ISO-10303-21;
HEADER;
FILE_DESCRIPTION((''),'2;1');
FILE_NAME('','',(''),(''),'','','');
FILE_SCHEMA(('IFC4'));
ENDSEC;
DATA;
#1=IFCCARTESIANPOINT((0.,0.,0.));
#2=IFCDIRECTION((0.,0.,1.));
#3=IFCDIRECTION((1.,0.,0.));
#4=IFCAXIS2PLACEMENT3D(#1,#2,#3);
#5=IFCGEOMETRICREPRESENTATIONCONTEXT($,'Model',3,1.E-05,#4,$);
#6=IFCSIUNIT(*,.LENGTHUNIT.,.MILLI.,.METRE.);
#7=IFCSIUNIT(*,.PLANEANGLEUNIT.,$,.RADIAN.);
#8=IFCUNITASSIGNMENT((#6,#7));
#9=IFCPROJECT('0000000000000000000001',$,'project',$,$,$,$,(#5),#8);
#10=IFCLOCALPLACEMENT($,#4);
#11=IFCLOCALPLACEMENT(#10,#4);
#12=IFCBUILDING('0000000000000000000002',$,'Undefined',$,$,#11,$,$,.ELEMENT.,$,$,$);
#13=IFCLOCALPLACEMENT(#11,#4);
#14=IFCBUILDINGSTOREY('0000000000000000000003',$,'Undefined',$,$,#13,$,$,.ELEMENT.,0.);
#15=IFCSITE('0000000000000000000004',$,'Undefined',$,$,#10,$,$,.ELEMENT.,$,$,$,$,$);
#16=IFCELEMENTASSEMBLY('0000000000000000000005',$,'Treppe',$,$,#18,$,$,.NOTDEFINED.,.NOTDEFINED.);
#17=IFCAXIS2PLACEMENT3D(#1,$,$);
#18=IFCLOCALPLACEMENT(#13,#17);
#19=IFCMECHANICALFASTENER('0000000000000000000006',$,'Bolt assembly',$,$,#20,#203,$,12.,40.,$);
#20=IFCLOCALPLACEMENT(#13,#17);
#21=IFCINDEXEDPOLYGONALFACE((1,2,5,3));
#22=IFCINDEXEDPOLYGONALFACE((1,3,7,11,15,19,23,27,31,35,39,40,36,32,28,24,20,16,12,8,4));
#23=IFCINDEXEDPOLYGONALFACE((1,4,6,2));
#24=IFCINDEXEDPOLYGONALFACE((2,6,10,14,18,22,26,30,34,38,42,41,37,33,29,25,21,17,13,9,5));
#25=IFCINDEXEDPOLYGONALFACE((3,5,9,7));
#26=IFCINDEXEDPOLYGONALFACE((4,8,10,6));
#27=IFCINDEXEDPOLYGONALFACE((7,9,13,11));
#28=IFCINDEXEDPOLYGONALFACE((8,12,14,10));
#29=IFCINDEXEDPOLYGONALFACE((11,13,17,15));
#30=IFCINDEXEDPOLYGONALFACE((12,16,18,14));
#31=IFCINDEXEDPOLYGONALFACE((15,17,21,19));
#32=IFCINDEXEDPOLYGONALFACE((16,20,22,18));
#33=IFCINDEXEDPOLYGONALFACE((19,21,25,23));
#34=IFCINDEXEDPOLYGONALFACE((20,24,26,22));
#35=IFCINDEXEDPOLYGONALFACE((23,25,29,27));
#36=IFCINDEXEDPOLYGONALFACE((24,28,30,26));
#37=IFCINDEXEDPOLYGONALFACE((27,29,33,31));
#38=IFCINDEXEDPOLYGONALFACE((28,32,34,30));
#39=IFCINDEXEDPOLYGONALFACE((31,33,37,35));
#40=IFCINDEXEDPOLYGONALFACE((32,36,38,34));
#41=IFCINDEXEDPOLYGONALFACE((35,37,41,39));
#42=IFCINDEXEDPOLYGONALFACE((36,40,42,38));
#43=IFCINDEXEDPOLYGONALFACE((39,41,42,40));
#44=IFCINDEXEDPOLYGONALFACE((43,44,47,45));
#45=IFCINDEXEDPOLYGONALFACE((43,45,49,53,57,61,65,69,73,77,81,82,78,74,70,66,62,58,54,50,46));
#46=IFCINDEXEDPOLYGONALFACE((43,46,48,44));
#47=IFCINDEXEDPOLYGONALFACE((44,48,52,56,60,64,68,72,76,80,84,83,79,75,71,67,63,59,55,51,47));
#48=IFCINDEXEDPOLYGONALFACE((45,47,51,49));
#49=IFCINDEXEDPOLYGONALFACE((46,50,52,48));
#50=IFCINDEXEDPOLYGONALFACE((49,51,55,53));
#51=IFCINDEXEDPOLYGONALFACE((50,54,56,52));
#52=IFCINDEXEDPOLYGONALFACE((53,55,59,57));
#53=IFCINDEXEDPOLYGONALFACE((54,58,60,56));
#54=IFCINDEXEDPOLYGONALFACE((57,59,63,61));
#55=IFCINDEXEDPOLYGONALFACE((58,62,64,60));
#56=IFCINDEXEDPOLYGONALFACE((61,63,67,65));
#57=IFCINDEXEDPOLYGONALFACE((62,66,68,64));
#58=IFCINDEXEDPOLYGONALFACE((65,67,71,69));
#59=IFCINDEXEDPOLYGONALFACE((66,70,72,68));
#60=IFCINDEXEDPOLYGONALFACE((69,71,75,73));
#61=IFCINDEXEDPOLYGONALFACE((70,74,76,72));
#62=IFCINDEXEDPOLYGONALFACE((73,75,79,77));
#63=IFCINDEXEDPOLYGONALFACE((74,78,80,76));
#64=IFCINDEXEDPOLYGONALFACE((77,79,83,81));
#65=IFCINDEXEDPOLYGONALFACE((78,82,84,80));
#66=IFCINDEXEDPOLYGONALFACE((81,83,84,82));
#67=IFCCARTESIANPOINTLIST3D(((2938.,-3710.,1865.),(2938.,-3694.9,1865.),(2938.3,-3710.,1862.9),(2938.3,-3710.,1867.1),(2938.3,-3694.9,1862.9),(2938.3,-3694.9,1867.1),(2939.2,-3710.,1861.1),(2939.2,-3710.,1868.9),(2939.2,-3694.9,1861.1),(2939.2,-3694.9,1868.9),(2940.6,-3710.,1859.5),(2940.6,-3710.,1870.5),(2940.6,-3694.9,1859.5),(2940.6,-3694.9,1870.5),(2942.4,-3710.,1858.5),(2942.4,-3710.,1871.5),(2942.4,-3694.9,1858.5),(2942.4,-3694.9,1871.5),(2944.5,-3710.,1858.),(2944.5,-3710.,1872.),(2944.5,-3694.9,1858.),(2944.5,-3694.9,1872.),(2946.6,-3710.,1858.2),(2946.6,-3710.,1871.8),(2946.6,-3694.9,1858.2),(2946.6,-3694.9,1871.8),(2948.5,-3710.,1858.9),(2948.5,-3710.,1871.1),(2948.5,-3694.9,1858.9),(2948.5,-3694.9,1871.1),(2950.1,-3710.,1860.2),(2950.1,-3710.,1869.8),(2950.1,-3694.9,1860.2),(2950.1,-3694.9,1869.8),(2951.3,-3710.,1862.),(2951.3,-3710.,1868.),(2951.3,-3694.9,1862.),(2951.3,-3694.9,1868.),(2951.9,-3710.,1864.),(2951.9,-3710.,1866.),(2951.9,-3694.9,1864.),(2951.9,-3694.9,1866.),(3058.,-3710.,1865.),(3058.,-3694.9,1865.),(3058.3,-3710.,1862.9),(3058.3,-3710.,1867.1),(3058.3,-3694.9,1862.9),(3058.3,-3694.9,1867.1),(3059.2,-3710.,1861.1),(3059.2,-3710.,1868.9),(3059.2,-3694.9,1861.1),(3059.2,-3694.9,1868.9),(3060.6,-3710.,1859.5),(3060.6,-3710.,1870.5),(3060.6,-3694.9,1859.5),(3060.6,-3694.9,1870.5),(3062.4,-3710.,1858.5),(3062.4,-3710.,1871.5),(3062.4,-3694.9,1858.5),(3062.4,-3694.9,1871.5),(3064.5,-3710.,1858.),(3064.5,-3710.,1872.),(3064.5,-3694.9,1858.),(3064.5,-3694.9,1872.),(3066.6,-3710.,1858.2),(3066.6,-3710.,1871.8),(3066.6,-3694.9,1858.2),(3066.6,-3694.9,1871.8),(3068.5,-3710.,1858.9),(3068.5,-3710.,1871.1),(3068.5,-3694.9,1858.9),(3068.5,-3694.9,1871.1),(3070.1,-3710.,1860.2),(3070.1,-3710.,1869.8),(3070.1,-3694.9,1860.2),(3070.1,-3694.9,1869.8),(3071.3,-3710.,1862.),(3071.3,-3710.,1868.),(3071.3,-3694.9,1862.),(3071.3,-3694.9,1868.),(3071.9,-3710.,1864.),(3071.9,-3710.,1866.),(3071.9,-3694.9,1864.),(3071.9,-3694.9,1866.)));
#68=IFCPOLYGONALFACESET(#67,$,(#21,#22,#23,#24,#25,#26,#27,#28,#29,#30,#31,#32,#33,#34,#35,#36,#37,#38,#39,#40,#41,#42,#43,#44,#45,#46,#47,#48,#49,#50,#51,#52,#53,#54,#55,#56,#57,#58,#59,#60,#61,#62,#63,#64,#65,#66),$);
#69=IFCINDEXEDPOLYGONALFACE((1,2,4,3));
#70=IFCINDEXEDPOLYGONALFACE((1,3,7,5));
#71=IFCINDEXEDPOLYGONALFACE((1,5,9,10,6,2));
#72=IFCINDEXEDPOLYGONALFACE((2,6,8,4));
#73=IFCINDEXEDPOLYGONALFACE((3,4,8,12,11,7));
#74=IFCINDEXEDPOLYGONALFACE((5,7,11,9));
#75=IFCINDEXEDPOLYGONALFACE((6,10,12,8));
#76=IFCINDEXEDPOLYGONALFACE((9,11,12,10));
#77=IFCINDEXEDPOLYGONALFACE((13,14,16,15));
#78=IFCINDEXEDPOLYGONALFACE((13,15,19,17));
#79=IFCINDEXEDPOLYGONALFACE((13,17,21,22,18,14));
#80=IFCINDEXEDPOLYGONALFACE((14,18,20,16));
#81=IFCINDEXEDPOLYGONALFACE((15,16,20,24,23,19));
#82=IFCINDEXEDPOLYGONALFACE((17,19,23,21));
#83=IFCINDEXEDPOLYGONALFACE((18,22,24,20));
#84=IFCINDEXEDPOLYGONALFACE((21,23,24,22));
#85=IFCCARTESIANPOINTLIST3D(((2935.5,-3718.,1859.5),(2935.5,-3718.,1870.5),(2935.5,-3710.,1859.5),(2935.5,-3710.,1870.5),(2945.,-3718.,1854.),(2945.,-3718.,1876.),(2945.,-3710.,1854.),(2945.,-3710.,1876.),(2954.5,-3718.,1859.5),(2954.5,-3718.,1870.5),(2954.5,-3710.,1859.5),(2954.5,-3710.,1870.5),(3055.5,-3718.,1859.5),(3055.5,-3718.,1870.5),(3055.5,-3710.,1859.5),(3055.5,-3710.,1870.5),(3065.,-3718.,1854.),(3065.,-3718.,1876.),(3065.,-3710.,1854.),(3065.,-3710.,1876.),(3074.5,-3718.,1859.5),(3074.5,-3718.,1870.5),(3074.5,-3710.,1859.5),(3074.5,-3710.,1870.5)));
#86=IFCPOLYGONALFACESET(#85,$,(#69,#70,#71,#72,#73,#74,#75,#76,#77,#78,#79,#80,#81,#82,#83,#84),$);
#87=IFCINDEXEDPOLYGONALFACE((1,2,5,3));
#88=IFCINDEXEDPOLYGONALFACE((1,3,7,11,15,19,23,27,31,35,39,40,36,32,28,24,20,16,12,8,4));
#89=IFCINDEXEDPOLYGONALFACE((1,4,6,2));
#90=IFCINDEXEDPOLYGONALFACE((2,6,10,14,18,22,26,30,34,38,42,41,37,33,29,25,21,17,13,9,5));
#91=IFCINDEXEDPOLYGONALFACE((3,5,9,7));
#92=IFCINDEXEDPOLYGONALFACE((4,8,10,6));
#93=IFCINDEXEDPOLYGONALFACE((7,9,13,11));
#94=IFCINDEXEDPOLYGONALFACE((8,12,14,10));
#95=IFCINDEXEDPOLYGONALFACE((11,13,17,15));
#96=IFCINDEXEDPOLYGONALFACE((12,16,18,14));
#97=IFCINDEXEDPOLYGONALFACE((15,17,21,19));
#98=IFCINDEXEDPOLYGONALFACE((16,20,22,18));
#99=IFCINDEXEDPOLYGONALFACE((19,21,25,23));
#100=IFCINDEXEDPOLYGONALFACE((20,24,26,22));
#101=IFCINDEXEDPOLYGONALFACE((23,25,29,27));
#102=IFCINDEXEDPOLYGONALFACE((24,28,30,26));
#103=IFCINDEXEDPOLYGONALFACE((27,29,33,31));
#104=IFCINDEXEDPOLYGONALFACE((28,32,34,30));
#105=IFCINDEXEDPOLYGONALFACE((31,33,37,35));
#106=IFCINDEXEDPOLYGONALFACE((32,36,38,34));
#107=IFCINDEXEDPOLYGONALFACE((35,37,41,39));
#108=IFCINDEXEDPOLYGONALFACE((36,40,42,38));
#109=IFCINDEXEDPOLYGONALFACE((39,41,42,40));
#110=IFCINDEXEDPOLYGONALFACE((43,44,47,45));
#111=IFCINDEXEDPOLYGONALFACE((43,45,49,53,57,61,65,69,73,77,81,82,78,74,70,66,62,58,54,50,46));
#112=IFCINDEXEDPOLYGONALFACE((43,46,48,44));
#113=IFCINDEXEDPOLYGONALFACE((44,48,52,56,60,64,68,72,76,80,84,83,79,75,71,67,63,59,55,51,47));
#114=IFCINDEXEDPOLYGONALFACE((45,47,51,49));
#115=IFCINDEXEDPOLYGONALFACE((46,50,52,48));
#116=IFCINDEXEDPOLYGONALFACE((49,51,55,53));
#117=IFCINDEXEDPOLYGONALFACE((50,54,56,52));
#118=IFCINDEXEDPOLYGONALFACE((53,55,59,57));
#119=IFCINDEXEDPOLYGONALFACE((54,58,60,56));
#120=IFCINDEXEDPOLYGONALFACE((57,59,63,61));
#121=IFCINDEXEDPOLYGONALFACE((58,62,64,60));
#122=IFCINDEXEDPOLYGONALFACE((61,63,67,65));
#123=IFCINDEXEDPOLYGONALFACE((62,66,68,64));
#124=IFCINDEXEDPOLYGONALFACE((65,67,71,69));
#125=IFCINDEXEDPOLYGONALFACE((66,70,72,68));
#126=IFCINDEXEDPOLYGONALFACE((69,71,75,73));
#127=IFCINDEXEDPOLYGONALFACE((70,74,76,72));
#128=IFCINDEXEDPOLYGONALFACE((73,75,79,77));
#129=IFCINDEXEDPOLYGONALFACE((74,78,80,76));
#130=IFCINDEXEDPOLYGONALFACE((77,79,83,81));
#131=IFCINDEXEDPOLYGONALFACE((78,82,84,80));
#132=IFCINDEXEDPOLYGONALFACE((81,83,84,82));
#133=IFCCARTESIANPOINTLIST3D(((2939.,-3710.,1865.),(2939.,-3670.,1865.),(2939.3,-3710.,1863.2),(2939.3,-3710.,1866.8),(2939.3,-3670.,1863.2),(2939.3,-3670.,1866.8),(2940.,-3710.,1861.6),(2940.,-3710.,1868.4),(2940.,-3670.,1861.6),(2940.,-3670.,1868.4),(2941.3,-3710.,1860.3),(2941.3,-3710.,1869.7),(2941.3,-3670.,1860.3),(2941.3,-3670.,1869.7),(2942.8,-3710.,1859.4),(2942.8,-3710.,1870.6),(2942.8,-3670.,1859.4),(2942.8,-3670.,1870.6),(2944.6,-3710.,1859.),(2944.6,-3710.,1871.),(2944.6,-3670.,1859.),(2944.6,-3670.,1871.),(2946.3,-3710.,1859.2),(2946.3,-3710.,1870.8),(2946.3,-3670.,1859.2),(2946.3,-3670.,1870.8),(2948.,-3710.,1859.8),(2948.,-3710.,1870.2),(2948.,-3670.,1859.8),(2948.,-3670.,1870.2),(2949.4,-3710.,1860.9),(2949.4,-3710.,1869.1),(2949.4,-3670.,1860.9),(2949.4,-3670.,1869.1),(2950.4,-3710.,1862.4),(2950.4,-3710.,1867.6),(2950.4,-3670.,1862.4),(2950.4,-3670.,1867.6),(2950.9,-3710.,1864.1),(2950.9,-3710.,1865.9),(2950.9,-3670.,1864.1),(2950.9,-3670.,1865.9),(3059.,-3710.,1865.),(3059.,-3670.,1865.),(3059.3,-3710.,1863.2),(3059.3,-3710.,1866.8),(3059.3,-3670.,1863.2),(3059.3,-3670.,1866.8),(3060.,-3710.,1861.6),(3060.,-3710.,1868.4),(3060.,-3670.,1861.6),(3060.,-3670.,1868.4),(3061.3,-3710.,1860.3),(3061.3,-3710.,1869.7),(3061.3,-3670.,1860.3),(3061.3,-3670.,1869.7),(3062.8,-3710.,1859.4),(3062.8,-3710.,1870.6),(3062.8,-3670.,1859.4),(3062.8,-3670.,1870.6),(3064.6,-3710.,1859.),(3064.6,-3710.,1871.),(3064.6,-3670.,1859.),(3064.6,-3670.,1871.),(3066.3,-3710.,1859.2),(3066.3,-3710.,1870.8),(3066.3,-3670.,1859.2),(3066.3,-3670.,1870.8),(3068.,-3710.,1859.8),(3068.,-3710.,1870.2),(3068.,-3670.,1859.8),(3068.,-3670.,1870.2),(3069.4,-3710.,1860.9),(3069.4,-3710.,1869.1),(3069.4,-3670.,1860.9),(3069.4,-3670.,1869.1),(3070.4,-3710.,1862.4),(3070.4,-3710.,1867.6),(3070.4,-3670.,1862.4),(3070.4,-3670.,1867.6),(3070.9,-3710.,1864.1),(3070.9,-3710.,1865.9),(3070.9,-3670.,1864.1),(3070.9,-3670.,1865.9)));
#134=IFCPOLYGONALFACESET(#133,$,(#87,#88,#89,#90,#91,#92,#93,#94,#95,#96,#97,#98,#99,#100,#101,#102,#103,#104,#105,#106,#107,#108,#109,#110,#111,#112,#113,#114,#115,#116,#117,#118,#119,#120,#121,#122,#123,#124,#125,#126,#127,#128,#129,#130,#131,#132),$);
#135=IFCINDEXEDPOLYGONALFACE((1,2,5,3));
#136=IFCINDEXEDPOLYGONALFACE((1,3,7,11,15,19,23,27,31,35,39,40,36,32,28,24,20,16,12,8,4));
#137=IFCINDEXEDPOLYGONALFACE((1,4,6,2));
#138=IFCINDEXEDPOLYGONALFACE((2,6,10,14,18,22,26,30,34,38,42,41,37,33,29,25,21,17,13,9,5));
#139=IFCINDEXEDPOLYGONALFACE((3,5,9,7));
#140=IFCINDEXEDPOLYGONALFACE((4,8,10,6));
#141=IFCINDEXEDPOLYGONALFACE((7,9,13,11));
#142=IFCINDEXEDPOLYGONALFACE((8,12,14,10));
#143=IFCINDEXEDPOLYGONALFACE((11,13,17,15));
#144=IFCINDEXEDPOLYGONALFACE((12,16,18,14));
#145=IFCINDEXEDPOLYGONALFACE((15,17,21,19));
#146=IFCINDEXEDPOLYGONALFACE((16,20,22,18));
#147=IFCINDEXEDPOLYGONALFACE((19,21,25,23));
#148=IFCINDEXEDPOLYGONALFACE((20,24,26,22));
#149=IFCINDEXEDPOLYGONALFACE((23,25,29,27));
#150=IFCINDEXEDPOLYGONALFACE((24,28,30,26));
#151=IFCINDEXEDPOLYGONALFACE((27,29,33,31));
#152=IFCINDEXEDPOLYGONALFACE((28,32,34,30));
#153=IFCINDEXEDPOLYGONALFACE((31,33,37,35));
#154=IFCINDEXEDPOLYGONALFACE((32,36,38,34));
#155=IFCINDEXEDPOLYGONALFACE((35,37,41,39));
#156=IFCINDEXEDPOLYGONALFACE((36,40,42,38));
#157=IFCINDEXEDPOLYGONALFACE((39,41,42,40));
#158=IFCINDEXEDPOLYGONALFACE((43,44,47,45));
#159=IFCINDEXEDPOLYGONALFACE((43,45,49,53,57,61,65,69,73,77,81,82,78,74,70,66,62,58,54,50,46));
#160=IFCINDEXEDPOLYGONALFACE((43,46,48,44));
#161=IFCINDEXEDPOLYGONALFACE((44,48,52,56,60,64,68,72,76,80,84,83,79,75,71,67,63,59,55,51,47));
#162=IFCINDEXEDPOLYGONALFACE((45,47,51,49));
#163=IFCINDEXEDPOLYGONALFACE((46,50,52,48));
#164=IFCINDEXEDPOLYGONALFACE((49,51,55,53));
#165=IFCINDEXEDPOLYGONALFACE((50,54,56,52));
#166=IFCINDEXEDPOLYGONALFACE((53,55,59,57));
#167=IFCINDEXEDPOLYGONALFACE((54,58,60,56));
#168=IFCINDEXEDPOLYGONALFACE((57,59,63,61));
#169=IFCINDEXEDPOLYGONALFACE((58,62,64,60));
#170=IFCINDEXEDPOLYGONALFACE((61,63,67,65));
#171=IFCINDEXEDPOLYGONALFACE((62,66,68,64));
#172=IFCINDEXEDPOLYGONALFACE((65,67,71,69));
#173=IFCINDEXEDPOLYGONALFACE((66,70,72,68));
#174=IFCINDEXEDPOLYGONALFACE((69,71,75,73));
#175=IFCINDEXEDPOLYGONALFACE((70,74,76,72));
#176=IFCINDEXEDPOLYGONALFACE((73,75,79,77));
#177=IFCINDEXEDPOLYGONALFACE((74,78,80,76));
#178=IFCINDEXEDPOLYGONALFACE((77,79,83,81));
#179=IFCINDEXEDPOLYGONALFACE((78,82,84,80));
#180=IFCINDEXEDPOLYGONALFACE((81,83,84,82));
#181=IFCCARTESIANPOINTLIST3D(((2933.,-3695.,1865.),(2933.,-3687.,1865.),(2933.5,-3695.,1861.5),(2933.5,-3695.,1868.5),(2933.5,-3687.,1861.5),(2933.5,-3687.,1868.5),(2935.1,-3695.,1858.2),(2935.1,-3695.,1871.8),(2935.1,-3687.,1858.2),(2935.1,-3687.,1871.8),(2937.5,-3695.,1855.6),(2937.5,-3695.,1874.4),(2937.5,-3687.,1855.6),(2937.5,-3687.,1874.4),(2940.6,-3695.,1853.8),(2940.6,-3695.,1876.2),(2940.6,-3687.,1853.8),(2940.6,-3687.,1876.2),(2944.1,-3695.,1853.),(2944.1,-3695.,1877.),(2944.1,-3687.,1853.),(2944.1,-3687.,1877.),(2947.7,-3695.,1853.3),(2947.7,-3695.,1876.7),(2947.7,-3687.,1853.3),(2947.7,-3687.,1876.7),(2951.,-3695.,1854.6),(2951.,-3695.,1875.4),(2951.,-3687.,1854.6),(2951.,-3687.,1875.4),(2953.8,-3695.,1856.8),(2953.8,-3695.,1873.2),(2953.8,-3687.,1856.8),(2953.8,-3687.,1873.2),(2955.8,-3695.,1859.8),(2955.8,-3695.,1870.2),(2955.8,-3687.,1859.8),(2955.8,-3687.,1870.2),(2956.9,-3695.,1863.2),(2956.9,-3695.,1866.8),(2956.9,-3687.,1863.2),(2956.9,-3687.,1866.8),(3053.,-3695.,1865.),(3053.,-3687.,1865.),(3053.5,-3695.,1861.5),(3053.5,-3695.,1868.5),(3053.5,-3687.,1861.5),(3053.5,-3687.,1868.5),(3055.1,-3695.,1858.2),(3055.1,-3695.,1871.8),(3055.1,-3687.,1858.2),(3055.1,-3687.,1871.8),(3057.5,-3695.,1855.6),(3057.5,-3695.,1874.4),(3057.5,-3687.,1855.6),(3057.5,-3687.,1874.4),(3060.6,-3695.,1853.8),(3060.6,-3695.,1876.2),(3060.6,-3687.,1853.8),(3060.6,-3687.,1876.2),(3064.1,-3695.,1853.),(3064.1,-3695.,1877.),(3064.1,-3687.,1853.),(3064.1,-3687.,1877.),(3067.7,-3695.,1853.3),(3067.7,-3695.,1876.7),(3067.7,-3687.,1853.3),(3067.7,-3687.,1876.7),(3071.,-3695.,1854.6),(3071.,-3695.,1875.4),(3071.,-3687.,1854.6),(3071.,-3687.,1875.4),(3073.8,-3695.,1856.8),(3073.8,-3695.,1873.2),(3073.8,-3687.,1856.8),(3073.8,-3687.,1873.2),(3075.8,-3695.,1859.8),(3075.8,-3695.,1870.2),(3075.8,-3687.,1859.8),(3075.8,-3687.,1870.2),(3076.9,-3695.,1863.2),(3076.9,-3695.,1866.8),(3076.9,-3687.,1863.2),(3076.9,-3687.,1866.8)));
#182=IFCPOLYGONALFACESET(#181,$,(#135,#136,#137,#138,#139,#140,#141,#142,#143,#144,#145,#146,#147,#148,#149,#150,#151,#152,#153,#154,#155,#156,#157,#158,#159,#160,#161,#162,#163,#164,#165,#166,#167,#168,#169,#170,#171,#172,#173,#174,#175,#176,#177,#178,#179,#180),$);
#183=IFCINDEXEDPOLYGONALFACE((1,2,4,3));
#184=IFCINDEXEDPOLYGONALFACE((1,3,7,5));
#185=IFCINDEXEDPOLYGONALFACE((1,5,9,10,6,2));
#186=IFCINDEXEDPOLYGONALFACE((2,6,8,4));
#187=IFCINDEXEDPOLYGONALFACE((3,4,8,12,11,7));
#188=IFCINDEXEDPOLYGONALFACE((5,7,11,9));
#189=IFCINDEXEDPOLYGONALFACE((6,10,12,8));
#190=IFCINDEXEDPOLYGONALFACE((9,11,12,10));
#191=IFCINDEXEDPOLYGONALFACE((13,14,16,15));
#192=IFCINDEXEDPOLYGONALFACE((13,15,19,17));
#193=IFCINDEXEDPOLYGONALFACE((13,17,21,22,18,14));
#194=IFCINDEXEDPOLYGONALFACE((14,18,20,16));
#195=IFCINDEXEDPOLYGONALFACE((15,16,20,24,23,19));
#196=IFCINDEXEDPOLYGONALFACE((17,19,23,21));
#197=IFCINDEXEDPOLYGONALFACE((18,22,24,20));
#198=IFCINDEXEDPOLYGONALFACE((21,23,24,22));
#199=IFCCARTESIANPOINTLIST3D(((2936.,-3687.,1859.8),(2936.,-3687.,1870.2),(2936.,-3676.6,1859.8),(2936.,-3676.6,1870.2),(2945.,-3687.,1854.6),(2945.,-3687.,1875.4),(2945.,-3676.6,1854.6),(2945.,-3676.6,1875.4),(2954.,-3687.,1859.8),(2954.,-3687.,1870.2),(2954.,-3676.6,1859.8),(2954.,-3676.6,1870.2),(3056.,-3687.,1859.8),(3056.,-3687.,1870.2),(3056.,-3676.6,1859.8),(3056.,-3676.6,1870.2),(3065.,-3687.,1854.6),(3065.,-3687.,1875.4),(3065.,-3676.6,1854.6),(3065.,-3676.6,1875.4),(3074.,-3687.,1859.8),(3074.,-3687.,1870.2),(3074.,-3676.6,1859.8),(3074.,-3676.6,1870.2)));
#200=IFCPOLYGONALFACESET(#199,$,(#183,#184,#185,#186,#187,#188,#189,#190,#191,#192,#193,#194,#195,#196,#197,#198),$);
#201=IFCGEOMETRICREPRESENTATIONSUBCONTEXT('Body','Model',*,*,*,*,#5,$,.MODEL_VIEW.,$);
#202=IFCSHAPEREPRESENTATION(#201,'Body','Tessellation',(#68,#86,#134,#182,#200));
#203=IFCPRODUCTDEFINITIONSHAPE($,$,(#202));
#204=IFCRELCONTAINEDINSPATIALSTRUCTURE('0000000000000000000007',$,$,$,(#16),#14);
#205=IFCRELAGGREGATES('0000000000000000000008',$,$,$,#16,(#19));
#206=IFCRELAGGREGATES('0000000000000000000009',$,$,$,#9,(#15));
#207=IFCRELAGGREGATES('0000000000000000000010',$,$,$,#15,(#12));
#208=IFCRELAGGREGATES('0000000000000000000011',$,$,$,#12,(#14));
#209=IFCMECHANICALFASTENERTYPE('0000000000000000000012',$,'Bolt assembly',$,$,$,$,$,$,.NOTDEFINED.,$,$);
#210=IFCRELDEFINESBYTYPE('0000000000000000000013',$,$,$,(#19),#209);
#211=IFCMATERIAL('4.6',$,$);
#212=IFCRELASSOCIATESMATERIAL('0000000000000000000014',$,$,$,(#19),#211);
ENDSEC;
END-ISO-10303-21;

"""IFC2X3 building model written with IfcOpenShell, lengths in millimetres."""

from ifc_helpers import new_model, si_unit, frame, origin_with_axes, origin_2d_with_axis, place, context, subcontext, project, spatial, polyline, circle, outline, extrude, source, transform, mapped, material, type_object, element, aggregate, save


model = new_model("IFC2X3")

# Units and contexts
model_context = context("Model", 3, precision=1e-05, world=origin_with_axes())
body_context = subcontext(model_context, "Body", "Model", "MODEL_VIEW")
ifc_project = project(units=[si_unit("LENGTHUNIT", "METRE", prefix="MILLI"), si_unit("PLANEANGLEUNIT", "RADIAN")], contexts=[model_context])

# Site, building, storey
site_placement = place(None, origin_with_axes())
site = spatial("IfcSite", under=ifc_project, at=site_placement, Name="Undefined", CompositionType="ELEMENT")
building_placement = place(site_placement, origin_with_axes())
building = spatial("IfcBuilding", under=site, at=building_placement, Name="Undefined", CompositionType="ELEMENT")
storey_placement = place(building_placement, origin_with_axes())
storey = spatial("IfcBuildingStorey", under=building, at=storey_placement, Name="Undefined", CompositionType="ELEMENT", Elevation=0.0)

# Element assembly, mechanical fastener
assembly_1_placement = place(storey_placement, origin_with_axes())
assembly_1 = element("IfcElementAssembly", 1, at=assembly_1_placement, inside=storey, Name="Treppe", AssemblyPlace="NOTDEFINED", PredefinedType="NOTDEFINED")
ifc_material_1 = material(Name="4.6")
mechanical_fastener_type = type_object("IfcMechanicalFastenerType", Name="Bolt assembly")
shared_shape_1 = source(origin_with_axes(), body_context, "Body", "SweptSolid", [
    extrude(circle(Radius=7.0, at=origin_2d_with_axis()), frame((0.0, 0.0, 0.0), z_axis=(0.0, 1.0, 0.0), x_axis=(1.0, 0.0, 0.0)), (0.0, 0.0, 1.0), 15.1),
    extrude(outline(polyline([(9.5, -5.5), (9.5, 5.5), (0.0, 11.0), (-9.5, 5.5), (-9.5, -5.5), (0.0, -11.0), (9.5, -5.5)])), frame((0.0, -8.0, 0.0), z_axis=(0.0, 1.0, 0.0), x_axis=(1.0, 0.0, 0.0)), (0.0, 0.0, 1.0), 8.0),
    extrude(circle(Radius=6.0, at=origin_2d_with_axis()), frame((0.0, 0.0, 0.0), z_axis=(0.0, 1.0, 0.0), x_axis=(1.0, 0.0, 0.0)), (0.0, 0.0, 1.0), 40.0),
    extrude(circle(Radius=12.0, at=origin_2d_with_axis()), frame((0.0, 15.0, 0.0), z_axis=(0.0, 1.0, 0.0), x_axis=(1.0, 0.0, 0.0)), (0.0, 0.0, 1.0), 8.0),
    extrude(outline(polyline([(9.0, -5.2), (9.0, 5.2), (0.0, 10.4), (-9.0, 5.2), (-9.0, -5.2), (0.0, -10.4), (9.0, -5.2)])), frame((0.0, 23.0, 0.0), z_axis=(0.0, 1.0, 0.0), x_axis=(1.0, 0.0, 0.0)), (0.0, 0.0, 1.0), 10.4),
])
mechanical_fastener_1_placement = place(assembly_1_placement, frame((3065.0, -3710.0, 1865.0), z_axis=(0.0, 0.0, -1.0), x_axis=(-1.0, 0.0, 0.0)))
mechanical_fastener_1 = element("IfcMechanicalFastener", 2, at=mechanical_fastener_1_placement, type_object=mechanical_fastener_type, material=ifc_material_1, Name="Bolt assembly", NominalDiameter=12.0, NominalLength=40.0, context=body_context, shape_type="MappedRepresentation", body=[
    mapped(shared_shape_1, transform((0.0, 0.0, 0.0))),
    mapped(shared_shape_1, transform((120.0, 0.0, 0.0))),
])
aggregate(assembly_1, [mechanical_fastener_1])

save(model, "model.ifc")
